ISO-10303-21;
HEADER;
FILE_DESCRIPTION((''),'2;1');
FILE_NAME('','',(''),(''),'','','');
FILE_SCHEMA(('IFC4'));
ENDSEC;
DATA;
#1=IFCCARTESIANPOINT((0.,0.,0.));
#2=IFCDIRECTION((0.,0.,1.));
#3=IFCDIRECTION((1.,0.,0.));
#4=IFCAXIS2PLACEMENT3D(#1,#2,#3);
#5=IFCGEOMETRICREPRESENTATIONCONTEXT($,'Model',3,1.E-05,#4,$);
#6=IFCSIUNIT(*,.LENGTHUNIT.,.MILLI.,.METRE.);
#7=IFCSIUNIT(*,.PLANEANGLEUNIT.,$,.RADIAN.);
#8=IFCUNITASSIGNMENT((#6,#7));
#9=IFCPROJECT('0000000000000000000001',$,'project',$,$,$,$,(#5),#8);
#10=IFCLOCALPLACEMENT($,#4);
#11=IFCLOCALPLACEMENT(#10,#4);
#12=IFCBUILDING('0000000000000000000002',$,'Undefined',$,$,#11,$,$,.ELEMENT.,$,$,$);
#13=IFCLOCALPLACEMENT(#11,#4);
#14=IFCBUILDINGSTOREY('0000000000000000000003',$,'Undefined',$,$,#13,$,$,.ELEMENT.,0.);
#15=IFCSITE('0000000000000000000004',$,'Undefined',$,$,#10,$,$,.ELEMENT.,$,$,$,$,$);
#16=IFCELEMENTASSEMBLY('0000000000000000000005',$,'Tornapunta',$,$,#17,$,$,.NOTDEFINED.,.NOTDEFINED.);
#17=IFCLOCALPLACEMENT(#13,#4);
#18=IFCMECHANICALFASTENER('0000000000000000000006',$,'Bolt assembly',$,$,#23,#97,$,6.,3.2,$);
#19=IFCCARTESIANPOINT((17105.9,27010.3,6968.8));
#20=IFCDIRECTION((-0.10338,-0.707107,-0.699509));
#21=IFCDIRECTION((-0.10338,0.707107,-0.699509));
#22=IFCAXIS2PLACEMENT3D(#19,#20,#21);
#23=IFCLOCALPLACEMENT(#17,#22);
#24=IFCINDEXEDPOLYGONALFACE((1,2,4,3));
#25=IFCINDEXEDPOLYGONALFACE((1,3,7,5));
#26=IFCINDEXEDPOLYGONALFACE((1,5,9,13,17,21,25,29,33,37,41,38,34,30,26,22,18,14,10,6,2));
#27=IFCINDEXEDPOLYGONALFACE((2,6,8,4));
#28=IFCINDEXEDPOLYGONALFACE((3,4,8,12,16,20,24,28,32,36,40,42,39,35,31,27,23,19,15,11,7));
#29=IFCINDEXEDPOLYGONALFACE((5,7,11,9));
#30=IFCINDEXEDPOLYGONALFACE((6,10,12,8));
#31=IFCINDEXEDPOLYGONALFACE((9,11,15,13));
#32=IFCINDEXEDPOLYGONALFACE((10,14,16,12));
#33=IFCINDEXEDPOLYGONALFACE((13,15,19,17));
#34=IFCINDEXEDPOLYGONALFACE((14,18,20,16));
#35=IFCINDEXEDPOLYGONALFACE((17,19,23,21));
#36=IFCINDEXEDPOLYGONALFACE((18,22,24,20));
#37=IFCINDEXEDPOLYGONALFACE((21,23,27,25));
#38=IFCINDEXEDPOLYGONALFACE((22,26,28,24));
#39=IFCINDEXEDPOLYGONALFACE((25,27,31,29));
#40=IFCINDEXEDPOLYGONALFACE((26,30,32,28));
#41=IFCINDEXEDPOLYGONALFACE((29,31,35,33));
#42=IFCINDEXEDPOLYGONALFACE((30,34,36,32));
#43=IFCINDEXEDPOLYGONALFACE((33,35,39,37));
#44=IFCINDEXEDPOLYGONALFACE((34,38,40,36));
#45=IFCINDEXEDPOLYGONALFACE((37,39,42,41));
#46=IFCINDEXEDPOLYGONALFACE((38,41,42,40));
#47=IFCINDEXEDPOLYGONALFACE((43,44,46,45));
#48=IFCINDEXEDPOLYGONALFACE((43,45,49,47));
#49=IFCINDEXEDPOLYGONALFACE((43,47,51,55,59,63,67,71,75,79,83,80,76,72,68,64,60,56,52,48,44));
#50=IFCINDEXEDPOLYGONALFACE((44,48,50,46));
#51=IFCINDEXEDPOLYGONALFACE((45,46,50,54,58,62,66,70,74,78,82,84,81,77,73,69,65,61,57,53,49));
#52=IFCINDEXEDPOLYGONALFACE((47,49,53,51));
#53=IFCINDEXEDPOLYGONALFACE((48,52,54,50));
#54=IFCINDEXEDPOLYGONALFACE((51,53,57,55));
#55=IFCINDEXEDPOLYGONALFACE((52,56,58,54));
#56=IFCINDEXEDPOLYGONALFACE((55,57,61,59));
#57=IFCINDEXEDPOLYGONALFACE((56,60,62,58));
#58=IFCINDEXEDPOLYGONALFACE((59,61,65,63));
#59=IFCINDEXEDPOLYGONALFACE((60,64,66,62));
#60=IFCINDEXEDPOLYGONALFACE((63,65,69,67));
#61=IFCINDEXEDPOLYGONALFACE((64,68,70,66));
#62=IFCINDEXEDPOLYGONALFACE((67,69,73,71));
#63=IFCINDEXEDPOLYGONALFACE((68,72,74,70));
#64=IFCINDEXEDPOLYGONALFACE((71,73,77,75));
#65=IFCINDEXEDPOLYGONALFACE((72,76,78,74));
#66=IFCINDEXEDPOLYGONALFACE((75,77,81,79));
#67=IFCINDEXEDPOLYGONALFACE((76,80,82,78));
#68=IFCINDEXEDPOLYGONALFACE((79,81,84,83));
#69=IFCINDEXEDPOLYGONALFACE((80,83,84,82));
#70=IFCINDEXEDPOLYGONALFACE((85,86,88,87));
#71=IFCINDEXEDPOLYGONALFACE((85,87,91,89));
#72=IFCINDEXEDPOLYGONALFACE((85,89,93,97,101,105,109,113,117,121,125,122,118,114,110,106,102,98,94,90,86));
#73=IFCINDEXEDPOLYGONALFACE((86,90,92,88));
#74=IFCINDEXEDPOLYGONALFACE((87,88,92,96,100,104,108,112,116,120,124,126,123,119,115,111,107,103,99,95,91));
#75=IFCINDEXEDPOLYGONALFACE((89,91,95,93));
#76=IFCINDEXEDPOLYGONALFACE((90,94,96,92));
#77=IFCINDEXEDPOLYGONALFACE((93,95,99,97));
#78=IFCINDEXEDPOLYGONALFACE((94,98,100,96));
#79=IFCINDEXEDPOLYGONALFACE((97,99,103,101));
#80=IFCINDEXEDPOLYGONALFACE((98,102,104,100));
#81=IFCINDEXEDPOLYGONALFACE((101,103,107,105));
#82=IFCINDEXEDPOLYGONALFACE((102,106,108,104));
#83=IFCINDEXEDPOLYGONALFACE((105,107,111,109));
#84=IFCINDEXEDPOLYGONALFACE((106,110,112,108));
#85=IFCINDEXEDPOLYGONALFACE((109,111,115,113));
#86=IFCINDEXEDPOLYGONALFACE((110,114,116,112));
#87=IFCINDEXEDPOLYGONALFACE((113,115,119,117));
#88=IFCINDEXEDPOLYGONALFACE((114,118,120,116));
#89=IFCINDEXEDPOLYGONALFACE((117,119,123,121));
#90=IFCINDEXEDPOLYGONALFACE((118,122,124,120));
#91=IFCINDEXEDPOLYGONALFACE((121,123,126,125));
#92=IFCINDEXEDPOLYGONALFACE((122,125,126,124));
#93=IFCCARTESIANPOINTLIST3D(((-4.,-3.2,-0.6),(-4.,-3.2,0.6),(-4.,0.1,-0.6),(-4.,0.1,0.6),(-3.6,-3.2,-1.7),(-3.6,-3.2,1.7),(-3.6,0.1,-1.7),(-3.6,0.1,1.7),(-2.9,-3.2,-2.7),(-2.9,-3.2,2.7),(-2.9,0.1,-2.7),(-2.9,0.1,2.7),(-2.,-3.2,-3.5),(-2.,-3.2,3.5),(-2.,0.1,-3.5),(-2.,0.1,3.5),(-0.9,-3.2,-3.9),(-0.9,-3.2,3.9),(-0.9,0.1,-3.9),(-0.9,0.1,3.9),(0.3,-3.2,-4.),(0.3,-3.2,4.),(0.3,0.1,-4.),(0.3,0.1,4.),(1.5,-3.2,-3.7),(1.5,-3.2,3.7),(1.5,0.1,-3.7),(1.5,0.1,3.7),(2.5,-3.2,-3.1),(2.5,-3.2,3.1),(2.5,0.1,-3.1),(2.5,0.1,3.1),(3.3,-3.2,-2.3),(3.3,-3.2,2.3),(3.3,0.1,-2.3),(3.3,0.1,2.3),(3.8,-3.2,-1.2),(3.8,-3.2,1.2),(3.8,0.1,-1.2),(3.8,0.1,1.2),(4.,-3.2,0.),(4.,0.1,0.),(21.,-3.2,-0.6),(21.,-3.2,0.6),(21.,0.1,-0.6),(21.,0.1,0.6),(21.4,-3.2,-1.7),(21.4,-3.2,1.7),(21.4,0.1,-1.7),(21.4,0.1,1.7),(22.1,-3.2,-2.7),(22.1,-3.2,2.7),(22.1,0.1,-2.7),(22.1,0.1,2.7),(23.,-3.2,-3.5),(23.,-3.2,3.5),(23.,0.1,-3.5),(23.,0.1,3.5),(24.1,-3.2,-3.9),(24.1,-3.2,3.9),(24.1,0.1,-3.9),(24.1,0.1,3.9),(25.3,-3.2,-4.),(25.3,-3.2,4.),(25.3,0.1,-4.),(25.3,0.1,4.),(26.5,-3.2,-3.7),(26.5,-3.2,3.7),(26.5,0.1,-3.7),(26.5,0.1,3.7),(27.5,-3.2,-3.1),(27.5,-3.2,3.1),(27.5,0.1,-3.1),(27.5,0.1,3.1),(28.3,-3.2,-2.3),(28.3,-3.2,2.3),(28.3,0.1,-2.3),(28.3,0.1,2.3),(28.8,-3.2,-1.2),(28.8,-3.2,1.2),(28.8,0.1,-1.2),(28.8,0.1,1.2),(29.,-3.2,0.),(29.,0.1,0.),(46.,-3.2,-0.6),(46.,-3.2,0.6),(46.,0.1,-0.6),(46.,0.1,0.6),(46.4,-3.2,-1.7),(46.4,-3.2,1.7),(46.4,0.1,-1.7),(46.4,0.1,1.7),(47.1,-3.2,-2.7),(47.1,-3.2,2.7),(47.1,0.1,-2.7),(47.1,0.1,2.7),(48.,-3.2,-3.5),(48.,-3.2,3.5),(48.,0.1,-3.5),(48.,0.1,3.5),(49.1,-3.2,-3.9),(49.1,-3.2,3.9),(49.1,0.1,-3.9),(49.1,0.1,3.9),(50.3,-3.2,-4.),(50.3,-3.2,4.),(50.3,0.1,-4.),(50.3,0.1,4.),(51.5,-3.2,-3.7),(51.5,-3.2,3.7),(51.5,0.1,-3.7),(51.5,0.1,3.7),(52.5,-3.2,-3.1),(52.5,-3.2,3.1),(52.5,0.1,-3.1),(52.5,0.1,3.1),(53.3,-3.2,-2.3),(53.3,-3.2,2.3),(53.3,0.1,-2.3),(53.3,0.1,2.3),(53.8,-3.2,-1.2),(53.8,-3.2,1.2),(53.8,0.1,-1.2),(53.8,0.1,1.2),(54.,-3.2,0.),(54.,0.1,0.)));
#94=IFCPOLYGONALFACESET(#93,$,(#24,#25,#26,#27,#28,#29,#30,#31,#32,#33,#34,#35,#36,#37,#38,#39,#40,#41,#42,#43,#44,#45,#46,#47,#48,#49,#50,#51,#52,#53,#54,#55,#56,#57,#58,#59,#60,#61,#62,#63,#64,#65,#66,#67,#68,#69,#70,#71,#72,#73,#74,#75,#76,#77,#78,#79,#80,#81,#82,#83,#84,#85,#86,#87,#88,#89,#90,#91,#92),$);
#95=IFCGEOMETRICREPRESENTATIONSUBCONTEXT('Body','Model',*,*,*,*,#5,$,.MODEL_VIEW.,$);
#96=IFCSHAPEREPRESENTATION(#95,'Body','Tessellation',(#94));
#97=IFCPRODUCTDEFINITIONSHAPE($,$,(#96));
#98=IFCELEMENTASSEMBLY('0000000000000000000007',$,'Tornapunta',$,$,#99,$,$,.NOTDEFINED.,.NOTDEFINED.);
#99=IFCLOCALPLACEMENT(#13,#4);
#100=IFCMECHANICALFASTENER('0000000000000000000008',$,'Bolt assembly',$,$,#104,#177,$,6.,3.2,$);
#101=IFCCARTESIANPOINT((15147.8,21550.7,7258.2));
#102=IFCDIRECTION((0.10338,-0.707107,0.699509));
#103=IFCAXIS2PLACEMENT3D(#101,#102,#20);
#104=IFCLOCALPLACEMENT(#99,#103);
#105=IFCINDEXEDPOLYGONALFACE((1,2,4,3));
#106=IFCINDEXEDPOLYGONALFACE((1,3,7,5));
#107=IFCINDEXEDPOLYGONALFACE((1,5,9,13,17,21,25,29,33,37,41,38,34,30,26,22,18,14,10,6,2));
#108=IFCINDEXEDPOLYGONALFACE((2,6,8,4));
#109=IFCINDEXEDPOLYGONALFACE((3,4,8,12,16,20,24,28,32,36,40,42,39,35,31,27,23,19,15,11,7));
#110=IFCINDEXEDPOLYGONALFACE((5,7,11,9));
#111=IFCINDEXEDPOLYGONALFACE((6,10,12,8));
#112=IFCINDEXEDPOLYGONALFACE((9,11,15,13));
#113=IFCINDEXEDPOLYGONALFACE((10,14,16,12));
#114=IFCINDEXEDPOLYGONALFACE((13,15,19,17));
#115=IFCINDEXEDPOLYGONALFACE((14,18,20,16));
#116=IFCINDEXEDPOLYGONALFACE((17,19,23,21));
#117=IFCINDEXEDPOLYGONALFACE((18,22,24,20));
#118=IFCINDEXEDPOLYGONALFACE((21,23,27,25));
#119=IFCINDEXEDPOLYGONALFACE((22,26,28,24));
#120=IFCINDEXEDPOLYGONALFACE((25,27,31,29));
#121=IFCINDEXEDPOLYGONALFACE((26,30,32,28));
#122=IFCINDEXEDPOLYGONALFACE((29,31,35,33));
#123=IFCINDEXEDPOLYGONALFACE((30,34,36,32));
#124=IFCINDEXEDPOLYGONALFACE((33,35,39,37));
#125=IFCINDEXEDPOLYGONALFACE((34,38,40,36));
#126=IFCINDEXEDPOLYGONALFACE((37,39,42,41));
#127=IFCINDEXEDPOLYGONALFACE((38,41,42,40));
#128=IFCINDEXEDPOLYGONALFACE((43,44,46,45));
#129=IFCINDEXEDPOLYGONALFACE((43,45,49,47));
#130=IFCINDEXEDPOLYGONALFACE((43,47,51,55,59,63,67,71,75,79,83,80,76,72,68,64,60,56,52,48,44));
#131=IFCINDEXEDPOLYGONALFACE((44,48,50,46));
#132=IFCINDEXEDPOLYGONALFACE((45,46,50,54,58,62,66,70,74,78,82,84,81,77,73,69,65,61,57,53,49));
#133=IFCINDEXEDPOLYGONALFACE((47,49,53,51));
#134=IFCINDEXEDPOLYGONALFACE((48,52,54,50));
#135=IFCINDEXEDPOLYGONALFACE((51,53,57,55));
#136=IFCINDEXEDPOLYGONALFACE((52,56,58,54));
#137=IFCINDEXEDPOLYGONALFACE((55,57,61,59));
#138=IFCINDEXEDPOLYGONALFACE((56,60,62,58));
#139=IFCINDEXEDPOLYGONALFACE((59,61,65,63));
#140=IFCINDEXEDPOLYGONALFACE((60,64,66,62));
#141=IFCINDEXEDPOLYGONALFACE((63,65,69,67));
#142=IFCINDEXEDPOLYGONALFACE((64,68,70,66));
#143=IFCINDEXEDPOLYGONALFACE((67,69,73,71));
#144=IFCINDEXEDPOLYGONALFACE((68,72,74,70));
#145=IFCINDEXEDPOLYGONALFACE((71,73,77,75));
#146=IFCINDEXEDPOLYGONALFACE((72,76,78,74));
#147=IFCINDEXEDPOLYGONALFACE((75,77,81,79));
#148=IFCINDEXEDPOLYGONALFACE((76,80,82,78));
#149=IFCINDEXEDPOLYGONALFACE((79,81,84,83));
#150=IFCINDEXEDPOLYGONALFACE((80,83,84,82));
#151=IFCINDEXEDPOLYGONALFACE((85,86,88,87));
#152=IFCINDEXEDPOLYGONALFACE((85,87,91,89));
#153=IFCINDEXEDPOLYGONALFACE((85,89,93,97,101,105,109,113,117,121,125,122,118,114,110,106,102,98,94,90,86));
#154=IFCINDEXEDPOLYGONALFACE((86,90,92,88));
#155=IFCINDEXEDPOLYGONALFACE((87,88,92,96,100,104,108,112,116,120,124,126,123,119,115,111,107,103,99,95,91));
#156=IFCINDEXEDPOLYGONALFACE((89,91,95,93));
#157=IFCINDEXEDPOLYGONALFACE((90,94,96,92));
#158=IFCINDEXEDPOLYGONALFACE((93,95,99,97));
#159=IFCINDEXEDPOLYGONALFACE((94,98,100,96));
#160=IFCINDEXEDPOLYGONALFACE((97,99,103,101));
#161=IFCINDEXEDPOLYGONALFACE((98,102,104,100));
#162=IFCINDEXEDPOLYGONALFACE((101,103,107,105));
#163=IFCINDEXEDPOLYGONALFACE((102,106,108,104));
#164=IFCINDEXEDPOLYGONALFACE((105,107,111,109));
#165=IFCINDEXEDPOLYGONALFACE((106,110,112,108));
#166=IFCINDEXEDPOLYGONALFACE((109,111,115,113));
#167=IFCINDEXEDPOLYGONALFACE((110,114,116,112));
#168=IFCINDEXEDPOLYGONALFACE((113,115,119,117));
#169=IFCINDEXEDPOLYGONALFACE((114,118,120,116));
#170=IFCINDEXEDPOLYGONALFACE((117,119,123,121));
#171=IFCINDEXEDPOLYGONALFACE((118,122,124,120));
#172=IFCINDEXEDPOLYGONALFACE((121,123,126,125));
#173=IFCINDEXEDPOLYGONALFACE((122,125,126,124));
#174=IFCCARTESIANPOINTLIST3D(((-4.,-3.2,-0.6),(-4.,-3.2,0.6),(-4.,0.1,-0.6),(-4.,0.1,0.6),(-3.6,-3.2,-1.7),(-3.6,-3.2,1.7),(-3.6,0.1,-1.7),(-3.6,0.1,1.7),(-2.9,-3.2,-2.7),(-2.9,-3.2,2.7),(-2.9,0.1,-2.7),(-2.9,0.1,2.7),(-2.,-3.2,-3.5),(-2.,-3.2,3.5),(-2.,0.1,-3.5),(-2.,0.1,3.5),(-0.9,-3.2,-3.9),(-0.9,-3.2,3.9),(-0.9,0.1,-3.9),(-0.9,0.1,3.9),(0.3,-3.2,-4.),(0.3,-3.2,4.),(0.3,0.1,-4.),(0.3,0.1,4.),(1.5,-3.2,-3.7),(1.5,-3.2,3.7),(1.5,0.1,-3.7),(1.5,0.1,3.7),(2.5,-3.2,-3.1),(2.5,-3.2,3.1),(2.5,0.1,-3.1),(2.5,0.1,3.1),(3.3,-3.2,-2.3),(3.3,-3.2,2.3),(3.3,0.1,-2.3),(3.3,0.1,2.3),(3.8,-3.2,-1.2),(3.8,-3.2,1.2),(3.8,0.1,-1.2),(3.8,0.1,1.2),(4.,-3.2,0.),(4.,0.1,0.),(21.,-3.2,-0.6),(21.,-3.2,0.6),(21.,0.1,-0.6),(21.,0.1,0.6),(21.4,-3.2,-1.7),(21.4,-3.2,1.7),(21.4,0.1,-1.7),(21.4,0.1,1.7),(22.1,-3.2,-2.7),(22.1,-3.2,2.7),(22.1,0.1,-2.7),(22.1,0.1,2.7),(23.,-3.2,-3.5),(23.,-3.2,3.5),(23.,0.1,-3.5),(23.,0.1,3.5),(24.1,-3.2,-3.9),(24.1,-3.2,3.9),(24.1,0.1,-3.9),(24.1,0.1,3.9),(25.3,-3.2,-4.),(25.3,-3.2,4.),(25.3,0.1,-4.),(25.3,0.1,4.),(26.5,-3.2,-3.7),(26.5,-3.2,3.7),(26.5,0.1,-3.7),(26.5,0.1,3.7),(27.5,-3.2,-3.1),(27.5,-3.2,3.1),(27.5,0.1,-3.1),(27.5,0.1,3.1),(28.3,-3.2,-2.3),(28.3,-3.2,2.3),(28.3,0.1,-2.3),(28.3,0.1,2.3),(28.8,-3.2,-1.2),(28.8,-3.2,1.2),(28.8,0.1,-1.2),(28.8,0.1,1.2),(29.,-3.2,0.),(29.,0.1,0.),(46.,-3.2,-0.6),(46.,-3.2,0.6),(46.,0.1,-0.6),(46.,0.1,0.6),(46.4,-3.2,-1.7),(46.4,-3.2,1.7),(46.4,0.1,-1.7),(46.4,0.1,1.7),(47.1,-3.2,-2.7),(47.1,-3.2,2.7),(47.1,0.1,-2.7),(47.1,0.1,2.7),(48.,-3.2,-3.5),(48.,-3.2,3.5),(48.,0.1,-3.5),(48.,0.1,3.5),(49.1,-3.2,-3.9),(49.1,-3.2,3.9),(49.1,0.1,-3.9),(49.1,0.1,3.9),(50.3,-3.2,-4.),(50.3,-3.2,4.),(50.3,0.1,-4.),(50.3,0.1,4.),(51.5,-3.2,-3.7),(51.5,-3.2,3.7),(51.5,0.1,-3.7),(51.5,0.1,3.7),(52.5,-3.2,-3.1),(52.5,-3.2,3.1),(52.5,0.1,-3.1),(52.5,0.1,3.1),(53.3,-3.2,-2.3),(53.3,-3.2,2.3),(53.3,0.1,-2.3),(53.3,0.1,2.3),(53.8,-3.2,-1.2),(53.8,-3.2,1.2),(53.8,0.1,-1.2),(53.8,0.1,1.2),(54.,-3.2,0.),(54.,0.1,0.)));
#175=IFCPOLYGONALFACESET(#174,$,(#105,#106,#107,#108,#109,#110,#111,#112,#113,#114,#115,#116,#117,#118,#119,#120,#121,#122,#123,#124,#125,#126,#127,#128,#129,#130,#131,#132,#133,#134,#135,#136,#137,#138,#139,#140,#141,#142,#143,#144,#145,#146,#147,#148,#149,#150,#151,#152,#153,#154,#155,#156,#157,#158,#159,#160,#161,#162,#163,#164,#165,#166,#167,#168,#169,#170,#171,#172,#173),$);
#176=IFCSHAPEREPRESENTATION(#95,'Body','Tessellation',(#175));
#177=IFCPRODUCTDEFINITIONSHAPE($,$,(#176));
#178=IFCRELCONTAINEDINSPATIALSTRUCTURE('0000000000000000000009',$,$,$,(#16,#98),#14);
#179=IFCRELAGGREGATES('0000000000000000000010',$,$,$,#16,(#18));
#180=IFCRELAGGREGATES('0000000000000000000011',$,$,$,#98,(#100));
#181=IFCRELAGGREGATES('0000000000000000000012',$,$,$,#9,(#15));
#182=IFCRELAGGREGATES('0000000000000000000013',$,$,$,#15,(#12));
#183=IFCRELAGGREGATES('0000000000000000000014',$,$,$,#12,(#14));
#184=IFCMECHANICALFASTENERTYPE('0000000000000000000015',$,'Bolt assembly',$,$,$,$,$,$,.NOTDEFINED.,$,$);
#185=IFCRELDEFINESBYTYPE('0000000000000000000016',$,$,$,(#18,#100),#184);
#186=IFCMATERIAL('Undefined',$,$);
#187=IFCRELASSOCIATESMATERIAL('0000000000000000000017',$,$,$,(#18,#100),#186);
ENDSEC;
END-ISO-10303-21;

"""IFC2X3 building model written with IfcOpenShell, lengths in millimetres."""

from ifc_helpers import new_model, si_unit, frame, origin_with_axes, origin_2d_with_axis, place, context, subcontext, project, spatial, circle, extrude, source, transform, mapped, material, type_object, element, aggregate, save


model = new_model("IFC2X3")

# Units and contexts
model_context = context("Model", 3, precision=1e-05, world=origin_with_axes())
body_context = subcontext(model_context, "Body", "Model", "MODEL_VIEW")
ifc_project = project(units=[si_unit("LENGTHUNIT", "METRE", prefix="MILLI"), si_unit("PLANEANGLEUNIT", "RADIAN")], contexts=[model_context])

# Site, building, storey
site_placement = place(None, origin_with_axes())
site = spatial("IfcSite", under=ifc_project, at=site_placement, Name="Undefined", CompositionType="ELEMENT")
building_placement = place(site_placement, origin_with_axes())
building = spatial("IfcBuilding", under=site, at=building_placement, Name="Undefined", CompositionType="ELEMENT")
storey_placement = place(building_placement, origin_with_axes())
storey = spatial("IfcBuildingStorey", under=building, at=storey_placement, Name="Undefined", CompositionType="ELEMENT", Elevation=0.0)

# Shared definitions
ifc_material_1 = material(Name="Undefined")
mechanical_fastener_type = type_object("IfcMechanicalFastenerType", Name="Bolt assembly")

# Element assemblies, mechanical fasteners
shared_shape_1 = source(origin_with_axes(), body_context, "Body", "SweptSolid", [
    extrude(circle(Radius=4.0, at=origin_2d_with_axis()), frame((0.0, -3.2, 0.0), z_axis=(0.0, 1.0, 0.0), x_axis=(1.0, 0.0, 0.0)), (0.0, 0.0, 1.0), 3.3),
])
assembly_1_placement = place(storey_placement, origin_with_axes())
assembly_1 = element("IfcElementAssembly", 1, at=assembly_1_placement, inside=storey, Name="Tornapunta", AssemblyPlace="NOTDEFINED", PredefinedType="NOTDEFINED")
mechanical_fastener_1_placement = place(assembly_1_placement, frame((17105.9, 27010.3, 6968.8), z_axis=(-0.10338, -0.707107, -0.699509), x_axis=(-0.10338, 0.707107, -0.699509)))
mechanical_fastener_1 = element("IfcMechanicalFastener", 2, at=mechanical_fastener_1_placement, type_object=mechanical_fastener_type, material=ifc_material_1, Name="Bolt assembly", NominalDiameter=6.0, NominalLength=3.2, context=body_context, shape_type="MappedRepresentation", body=[
    mapped(shared_shape_1, transform((0.0, 0.0, 0.0))),
    mapped(shared_shape_1, transform((25.0, 0.0, 0.0))),
    mapped(shared_shape_1, transform((50.0, 0.0, 0.0))),
])
aggregate(assembly_1, [mechanical_fastener_1])
assembly_2_placement = place(storey_placement, origin_with_axes())
assembly_2 = element("IfcElementAssembly", 3, at=assembly_2_placement, inside=storey, Name="Tornapunta", AssemblyPlace="NOTDEFINED", PredefinedType="NOTDEFINED")
mechanical_fastener_2_placement = place(assembly_2_placement, frame((15147.8, 21550.7, 7258.2), z_axis=(0.10338, -0.707107, 0.699509), x_axis=(-0.10338, -0.707107, -0.699509)))
mechanical_fastener_2 = element("IfcMechanicalFastener", 4, at=mechanical_fastener_2_placement, type_object=mechanical_fastener_type, material=ifc_material_1, Name="Bolt assembly", NominalDiameter=6.0, NominalLength=3.2, context=body_context, shape_type="MappedRepresentation", body=[
    mapped(shared_shape_1, transform((0.0, 0.0, 0.0))),
    mapped(shared_shape_1, transform((25.0, 0.0, 0.0))),
    mapped(shared_shape_1, transform((50.0, 0.0, 0.0))),
])
aggregate(assembly_2, [mechanical_fastener_2])

save(model, "model.ifc")
